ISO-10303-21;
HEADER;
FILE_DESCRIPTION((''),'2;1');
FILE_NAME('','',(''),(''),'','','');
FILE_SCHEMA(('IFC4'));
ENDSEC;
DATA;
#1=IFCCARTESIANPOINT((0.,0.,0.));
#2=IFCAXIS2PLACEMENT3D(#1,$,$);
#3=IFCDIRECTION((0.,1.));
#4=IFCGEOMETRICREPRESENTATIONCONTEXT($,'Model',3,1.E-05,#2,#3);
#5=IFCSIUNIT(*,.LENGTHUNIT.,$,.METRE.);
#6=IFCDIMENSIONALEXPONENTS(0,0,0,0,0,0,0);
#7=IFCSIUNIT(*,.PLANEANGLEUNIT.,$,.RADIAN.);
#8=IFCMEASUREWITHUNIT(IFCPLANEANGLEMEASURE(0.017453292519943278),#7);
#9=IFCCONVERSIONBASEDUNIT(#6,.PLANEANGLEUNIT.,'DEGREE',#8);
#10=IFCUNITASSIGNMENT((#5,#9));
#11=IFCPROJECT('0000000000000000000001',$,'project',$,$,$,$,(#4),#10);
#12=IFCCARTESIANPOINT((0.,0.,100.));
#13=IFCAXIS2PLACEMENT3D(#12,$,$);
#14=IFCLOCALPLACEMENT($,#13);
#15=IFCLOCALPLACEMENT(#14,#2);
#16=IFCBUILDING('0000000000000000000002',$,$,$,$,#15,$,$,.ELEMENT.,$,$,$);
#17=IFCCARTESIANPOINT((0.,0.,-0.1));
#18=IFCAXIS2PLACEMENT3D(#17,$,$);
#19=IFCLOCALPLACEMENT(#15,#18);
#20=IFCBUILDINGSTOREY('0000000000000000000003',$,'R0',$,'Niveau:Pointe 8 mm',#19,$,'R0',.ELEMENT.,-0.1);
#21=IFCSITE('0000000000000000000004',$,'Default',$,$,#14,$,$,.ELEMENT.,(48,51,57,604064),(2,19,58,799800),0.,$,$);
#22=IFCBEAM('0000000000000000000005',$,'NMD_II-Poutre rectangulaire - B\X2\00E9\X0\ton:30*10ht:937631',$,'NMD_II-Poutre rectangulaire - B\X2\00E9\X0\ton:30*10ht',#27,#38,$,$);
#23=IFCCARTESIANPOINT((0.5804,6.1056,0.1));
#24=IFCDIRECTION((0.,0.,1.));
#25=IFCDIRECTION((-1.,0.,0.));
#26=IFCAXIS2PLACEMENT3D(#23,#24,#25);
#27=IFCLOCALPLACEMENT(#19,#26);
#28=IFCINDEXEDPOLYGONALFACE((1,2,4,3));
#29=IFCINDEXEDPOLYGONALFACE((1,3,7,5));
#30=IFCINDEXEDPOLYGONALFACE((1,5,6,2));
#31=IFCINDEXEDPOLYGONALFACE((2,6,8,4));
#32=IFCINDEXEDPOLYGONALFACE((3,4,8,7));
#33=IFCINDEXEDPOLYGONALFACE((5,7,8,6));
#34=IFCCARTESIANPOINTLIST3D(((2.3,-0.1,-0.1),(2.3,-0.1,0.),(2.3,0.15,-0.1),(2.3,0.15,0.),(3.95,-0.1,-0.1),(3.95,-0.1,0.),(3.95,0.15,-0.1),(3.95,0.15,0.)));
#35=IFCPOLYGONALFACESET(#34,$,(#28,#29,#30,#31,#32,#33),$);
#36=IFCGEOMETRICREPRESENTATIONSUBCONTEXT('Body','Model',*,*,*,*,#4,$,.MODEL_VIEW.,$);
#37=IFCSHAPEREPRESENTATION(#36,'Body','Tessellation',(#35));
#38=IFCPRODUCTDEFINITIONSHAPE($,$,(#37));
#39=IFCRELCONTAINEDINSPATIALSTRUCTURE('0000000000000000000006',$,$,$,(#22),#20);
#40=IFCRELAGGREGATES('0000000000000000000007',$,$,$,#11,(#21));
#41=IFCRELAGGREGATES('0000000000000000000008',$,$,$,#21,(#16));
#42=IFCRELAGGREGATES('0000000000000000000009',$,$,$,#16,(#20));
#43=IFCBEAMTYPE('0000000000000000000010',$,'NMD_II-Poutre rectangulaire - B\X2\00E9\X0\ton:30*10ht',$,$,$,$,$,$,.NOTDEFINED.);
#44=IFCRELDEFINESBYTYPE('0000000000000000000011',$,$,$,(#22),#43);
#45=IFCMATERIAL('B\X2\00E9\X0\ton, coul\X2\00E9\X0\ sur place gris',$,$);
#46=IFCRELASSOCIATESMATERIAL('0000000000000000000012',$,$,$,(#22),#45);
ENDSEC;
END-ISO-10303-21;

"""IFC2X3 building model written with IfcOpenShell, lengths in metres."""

from ifc_helpers import new_model, entity, si_unit, converted_unit, direction, frame, frame_2d, origin, place, context, subcontext, project, spatial, rectangle, extrude, material, type_object, element, save


model = new_model("IFC2X3")

# Units and contexts
model_context = context("Model", 3, precision=1e-05, world=origin(), true_north=direction((0.0, 1.0)))
body_context = subcontext(model_context, "Body", "Model", "MODEL_VIEW")
ifc_project = project(units=[si_unit("LENGTHUNIT", "METRE"), converted_unit("PLANEANGLEUNIT", "DEGREE", entity("IfcPlaneAngleMeasure", 0.017453292519943278), si_unit("PLANEANGLEUNIT", "RADIAN"), dimensions=[0, 0, 0, 0, 0, 0, 0])], contexts=[model_context])

# Site, building, storey
site_placement = place(None, frame((0.0, 0.0, 100.0)))
site = spatial("IfcSite", under=ifc_project, at=site_placement, Name="Default", CompositionType="ELEMENT", RefLatitude=(48, 51, 57, 604064), RefLongitude=(2, 19, 58, 799800), RefElevation=0.0)
building_placement = place(site_placement, origin())
building = spatial("IfcBuilding", under=site, at=building_placement, CompositionType="ELEMENT")
storey_placement = place(building_placement, frame((0.0, 0.0, -0.1)))
storey = spatial("IfcBuildingStorey", under=building, at=storey_placement, Name="R0", ObjectType="Niveau:Pointe 8 mm", LongName="R0", CompositionType="ELEMENT", Elevation=-0.1)

# Beam
ifc_material_1 = material(Name="Béton, coulé sur place gris")
beam_type_1 = type_object("IfcBeamType", Name="NMD_II-Poutre rectangulaire - Béton:30*10ht", PredefinedType="NOTDEFINED")
beam_1_placement = place(storey_placement, frame((0.5804, 6.1056, 0.1), z_axis=(0.0, 0.0, 1.0), x_axis=(-1.0, 0.0, 0.0)))
element("IfcBeam", 1, at=beam_1_placement, inside=storey, type_object=beam_type_1, material=ifc_material_1, Name="NMD_II-Poutre rectangulaire - Béton:30*10ht:937631", ObjectType="NMD_II-Poutre rectangulaire - Béton:30*10ht", context=body_context, shape_type="SweptSolid", body=[
    extrude(rectangle(XDim=0.1, YDim=0.25, at=frame_2d((0.0, 0.0), x_axis=(1.0, 0.0))), frame((2.3, 0.025, -0.05), z_axis=(1.0, 0.0, 0.0), x_axis=(0.0, 0.0, -1.0)), (0.0, 0.0, 1.0), 1.65),
])

save(model, "model.ifc")
